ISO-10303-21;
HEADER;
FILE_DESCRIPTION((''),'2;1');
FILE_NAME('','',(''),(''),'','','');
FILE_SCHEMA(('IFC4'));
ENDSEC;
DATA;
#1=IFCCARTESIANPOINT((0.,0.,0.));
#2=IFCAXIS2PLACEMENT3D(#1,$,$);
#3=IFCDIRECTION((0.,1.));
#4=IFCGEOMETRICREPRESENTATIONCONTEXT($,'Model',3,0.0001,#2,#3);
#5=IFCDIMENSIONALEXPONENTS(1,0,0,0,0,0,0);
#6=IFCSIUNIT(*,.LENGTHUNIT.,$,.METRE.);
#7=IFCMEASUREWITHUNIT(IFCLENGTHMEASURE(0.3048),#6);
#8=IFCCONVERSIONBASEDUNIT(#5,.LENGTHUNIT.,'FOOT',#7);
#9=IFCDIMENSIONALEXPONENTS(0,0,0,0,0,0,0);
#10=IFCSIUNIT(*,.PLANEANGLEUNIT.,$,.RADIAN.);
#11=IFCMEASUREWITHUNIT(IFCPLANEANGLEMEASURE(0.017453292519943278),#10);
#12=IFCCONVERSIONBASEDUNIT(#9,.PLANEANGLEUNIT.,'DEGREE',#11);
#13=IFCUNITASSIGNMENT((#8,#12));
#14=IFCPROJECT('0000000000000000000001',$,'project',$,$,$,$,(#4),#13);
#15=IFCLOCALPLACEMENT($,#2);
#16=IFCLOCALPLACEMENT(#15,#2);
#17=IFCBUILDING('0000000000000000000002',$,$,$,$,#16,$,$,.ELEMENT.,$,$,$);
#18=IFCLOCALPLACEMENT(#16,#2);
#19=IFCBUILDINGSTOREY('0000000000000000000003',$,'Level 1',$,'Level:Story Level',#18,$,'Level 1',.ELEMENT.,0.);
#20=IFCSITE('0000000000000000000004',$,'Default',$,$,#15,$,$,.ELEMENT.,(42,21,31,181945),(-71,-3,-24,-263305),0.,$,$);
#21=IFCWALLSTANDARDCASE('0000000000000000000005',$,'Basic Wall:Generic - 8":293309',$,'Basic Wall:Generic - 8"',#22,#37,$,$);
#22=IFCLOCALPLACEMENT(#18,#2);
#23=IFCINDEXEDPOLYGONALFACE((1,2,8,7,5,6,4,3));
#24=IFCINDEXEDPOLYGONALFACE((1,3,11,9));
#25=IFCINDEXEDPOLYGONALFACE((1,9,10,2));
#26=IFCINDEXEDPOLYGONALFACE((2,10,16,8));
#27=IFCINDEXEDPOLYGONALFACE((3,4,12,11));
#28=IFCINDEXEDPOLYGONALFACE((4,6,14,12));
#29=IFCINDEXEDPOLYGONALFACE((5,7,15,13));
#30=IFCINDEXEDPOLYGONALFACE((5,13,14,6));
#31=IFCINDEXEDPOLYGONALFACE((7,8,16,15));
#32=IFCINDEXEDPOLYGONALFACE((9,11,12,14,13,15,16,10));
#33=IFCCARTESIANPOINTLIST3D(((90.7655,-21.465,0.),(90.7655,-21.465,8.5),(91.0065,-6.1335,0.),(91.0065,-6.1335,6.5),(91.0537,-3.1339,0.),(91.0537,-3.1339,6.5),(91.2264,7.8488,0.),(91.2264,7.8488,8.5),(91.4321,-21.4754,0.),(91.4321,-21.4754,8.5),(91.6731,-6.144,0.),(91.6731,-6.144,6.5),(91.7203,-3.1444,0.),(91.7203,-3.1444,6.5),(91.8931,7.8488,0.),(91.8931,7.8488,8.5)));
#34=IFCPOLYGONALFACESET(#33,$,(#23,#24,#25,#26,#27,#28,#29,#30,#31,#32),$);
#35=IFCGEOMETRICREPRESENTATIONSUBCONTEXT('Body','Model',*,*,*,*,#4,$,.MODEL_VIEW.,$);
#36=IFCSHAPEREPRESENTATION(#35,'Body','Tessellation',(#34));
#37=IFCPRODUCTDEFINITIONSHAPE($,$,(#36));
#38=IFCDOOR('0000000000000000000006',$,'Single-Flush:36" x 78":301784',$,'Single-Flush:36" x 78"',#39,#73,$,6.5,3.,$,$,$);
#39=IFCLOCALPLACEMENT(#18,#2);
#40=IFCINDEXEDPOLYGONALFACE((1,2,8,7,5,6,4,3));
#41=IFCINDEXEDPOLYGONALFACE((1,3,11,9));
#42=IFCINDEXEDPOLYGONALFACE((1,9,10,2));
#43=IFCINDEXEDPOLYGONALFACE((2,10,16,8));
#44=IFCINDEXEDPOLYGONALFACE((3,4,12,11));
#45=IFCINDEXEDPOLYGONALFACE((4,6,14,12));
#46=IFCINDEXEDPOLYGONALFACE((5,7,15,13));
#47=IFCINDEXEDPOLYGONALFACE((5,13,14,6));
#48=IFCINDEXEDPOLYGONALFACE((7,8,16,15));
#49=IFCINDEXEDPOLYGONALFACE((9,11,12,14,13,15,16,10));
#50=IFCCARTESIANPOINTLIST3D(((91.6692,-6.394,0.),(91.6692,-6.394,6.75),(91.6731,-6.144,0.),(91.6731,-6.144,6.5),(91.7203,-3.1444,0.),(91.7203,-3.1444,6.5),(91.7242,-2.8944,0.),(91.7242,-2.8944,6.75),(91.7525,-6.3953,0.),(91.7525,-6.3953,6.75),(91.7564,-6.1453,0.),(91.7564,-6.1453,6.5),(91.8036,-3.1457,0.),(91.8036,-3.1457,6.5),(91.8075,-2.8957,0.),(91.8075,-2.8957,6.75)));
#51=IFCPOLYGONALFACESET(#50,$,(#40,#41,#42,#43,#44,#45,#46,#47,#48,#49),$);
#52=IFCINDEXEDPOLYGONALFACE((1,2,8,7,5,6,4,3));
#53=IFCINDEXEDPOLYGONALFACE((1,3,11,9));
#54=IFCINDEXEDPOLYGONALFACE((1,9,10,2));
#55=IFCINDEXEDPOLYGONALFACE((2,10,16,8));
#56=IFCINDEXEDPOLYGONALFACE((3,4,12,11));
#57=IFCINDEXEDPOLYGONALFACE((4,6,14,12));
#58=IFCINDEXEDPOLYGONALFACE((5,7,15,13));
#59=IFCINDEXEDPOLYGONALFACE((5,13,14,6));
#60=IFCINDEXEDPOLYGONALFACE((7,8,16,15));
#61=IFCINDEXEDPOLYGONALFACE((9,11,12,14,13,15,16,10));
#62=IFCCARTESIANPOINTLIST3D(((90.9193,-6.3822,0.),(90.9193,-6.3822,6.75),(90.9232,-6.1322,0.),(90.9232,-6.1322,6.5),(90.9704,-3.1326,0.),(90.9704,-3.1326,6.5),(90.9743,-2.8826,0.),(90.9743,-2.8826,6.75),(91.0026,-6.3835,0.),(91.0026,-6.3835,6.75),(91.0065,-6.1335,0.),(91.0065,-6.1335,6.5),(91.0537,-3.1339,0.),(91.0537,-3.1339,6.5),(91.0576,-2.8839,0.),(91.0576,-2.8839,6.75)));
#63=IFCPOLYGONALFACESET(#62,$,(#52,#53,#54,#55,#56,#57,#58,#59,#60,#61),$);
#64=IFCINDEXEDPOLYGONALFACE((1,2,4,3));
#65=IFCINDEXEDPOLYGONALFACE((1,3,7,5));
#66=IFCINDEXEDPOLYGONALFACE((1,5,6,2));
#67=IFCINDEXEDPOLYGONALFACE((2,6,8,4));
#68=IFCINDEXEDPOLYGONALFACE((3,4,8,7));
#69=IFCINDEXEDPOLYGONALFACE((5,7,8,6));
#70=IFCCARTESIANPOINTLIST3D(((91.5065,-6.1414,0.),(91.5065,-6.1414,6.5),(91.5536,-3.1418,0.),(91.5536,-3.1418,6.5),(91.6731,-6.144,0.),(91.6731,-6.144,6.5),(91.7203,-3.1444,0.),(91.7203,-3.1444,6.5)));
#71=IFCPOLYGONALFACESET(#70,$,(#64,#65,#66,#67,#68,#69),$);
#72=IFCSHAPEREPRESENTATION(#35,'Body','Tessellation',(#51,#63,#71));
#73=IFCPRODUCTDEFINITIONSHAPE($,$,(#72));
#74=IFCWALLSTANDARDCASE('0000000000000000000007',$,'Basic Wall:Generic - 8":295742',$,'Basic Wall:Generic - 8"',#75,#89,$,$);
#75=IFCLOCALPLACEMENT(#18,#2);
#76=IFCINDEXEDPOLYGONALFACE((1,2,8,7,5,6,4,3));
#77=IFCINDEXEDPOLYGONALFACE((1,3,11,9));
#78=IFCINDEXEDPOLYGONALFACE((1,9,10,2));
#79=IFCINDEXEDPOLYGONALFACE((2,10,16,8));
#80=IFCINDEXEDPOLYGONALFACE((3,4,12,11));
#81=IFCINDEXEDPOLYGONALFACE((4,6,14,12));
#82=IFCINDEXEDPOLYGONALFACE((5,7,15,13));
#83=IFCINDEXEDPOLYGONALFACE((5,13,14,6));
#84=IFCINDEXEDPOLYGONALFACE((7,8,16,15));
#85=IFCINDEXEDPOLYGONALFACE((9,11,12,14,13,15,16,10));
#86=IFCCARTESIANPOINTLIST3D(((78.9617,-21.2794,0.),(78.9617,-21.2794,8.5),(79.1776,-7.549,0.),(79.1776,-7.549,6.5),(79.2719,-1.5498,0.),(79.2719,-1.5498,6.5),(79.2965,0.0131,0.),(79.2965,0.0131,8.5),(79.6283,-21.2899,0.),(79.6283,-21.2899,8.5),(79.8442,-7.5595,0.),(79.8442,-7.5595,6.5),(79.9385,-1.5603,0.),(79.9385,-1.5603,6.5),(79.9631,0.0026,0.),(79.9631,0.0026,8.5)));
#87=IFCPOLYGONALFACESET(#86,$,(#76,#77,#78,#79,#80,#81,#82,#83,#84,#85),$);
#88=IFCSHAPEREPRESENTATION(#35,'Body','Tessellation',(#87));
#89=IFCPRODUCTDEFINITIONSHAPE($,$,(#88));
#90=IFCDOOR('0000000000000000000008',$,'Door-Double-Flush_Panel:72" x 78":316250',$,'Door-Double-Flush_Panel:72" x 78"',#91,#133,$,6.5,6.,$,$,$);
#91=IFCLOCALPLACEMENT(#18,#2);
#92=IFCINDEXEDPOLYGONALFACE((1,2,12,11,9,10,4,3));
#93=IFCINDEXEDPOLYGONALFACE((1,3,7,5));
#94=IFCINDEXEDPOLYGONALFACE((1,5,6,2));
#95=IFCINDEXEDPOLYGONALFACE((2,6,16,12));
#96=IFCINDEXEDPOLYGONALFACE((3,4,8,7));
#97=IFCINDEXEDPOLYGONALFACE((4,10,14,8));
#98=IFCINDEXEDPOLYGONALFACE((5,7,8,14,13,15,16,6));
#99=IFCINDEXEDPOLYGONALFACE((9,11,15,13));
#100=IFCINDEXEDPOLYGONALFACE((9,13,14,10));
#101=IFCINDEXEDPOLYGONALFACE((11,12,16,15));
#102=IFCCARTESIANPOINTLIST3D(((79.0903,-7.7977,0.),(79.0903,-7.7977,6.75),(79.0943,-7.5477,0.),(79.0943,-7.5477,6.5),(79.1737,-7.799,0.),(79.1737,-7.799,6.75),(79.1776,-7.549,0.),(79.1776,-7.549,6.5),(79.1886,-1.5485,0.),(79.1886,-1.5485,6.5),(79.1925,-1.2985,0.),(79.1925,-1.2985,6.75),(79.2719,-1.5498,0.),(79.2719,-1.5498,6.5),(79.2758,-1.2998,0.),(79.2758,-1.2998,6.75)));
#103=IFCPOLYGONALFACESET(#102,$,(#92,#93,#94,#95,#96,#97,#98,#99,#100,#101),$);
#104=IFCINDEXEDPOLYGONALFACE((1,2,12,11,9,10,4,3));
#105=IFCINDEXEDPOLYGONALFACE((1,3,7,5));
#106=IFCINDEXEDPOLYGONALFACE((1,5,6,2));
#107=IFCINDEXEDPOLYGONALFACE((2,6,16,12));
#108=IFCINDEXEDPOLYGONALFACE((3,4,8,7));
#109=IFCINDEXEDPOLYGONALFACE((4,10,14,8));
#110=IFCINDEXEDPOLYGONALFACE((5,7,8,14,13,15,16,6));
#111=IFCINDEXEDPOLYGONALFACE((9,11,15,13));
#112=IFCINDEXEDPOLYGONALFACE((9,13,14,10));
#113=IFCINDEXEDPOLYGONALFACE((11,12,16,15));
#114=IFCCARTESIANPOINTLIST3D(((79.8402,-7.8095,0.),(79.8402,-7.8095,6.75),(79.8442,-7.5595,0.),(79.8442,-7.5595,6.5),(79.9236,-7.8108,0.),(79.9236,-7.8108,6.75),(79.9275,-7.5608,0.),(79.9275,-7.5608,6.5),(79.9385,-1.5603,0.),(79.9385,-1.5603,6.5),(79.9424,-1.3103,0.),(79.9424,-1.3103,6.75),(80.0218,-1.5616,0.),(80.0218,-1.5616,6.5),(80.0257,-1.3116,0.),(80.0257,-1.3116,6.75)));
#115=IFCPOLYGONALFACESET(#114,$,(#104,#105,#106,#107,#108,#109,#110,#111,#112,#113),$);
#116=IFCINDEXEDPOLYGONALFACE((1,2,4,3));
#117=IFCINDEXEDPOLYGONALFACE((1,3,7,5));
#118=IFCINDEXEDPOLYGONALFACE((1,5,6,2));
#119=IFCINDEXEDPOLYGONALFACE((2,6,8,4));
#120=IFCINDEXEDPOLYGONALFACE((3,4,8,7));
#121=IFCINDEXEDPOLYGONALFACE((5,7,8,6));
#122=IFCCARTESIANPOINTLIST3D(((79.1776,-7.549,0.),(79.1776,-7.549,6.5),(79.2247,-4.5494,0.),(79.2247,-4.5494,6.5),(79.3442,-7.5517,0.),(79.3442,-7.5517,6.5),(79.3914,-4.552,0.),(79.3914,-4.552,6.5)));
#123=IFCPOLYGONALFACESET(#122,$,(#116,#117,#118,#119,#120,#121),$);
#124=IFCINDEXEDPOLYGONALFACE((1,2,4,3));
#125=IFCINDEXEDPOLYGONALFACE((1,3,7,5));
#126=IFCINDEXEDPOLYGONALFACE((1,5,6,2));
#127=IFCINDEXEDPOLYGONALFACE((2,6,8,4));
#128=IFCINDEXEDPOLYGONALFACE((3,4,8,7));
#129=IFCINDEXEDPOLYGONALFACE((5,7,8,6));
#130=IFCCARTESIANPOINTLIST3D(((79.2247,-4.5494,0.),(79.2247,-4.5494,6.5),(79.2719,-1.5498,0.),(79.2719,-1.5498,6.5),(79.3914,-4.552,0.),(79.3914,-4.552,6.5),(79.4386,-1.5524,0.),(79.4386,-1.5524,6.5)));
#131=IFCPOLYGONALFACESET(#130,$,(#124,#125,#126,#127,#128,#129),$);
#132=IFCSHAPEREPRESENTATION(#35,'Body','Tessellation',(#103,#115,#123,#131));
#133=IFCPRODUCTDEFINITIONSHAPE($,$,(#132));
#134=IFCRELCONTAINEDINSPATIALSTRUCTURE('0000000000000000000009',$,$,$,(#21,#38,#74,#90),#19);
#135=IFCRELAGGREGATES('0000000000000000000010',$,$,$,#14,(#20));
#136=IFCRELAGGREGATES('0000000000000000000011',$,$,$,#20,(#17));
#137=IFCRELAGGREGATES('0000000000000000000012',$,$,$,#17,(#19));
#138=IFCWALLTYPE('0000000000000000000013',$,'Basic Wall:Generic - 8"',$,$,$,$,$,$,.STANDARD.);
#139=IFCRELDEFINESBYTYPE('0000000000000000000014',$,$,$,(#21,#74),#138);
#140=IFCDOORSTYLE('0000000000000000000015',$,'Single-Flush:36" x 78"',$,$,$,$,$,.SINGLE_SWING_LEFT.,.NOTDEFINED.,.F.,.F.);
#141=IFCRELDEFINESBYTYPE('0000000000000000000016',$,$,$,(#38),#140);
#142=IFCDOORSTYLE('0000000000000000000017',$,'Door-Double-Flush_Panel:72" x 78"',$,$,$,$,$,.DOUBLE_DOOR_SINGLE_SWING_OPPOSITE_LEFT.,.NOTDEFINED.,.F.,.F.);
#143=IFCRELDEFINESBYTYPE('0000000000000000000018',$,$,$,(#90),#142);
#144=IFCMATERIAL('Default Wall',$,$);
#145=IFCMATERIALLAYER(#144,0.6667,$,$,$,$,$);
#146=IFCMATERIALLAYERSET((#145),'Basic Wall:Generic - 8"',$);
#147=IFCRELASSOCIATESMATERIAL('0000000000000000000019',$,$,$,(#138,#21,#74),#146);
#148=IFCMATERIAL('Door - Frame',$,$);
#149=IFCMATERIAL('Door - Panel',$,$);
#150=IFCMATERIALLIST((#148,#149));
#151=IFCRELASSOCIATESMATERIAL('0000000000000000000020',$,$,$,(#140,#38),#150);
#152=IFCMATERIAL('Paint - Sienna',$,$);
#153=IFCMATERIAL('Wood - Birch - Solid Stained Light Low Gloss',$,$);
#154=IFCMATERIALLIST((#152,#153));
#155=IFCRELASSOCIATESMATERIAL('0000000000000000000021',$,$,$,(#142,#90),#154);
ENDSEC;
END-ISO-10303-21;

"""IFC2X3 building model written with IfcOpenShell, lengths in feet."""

from ifc_helpers import new_model, entity, si_unit, converted_unit, direction, frame, frame_2d, origin, place, context, subcontext, project, spatial, polyline, rectangle, outline, extrude, source, transform, mapped, material, material_list, layer, layer_set, layer_usage, type_object, type_shapes, element, fill, save


model = new_model("IFC2X3")

# Units and contexts
model_context = context("Model", 3, precision=0.0001, world=origin(), true_north=direction((0.0, 1.0)))
body_context = subcontext(model_context, "Body", "Model", "MODEL_VIEW")
ifc_project = project(units=[converted_unit("LENGTHUNIT", "FOOT", entity("IfcLengthMeasure", 0.3048), si_unit("LENGTHUNIT", "METRE"), dimensions=[1, 0, 0, 0, 0, 0, 0]), converted_unit("PLANEANGLEUNIT", "DEGREE", entity("IfcPlaneAngleMeasure", 0.017453292519943278), si_unit("PLANEANGLEUNIT", "RADIAN"), dimensions=[0, 0, 0, 0, 0, 0, 0])], contexts=[model_context])

# Site, building, storey
site_placement = place(None, origin())
site = spatial("IfcSite", under=ifc_project, at=site_placement, Name="Default", CompositionType="ELEMENT", RefLatitude=(42, 21, 31, 181945), RefLongitude=(-71, -3, -24, -263305), RefElevation=0.0)
building_placement = place(site_placement, origin())
building = spatial("IfcBuilding", under=site, at=building_placement, CompositionType="ELEMENT")
storey_placement = place(building_placement, origin())
storey = spatial("IfcBuildingStorey", under=building, at=storey_placement, Name="Level 1", ObjectType="Level:Story Level", LongName="Level 1", CompositionType="ELEMENT", Elevation=0.0)

# Walls, openings, doors
ifc_material_1 = material(Name="Default Wall")
ifc_layer_1 = layer(ifc_material_1, 0.6667)
ifc_layer_set_1 = layer_set([ifc_layer_1], Name="Basic Wall:Generic - 8\"")
ifc_layer_usage_1 = layer_usage(ifc_layer_set_1, "AXIS2", "NEGATIVE", 0.3333)
wall_type_1 = type_object("IfcWallType", Name="Basic Wall:Generic - 8\"", PredefinedType="STANDARD", material=ifc_layer_set_1)
wall_1_placement = place(storey_placement, frame((91.5598, 7.8541, 0.0), z_axis=(0.0, 0.0, 1.0), x_axis=(-0.015721, -0.999876, 0.0)))
wall_1 = element("IfcWallStandardCase", 1, at=wall_1_placement, inside=storey, type_object=wall_type_1, material=ifc_layer_usage_1, Name="Basic Wall:Generic - 8\":293309", ObjectType="Basic Wall:Generic - 8\"", context=body_context, shape_type="SweptSolid", body=[
    extrude(outline(polyline([(0.0105, -0.3333), (29.3279, -0.3333), (29.3279, 0.3333), (10.5258, 0.3333), (10.1195, 0.3333), (0.0, 0.3333), (0.0105, -0.3333)])), origin(), (0.0, 0.0, 1.0), 8.5),
])
opening_1_placement = place(wall_1_placement, frame((10.9946, -0.3333, 0.0)))
opening_1 = element("IfcOpeningElement", 2, at=opening_1_placement, cuts=wall_1, ObjectType="Opening", context=body_context, shape_type="SweptSolid", body=[
    extrude(rectangle(XDim=3.0, YDim=6.5, at=frame_2d((3.25, 1.5), x_axis=(0.0, -1.0))), frame((0.0, 0.0, 0.0), z_axis=(0.0, 1.0, 0.0), x_axis=(0.0, 0.0, 1.0)), (0.0, 0.0, 1.0), 0.6667),
])
ifc_material_2 = material(Name="Door - Frame")
ifc_material_3 = material(Name="Door - Panel")
ifc_material_list_1 = material_list([ifc_material_2, ifc_material_3])
door_style_1 = type_object("IfcDoorStyle", Name="Single-Flush:36\" x 78\"", ConstructionType="NOTDEFINED", OperationType="SINGLE_SWING_LEFT", ParameterTakesPrecedence=False, Sizeable=False, material=ifc_material_list_1)
shared_shape_1 = source(origin(), body_context, "Body", "SweptSolid", [
    extrude(outline(polyline([(-1.75, -3.4375), (1.75, -3.4375), (1.75, 3.3125), (1.5, 3.3125), (1.5, -3.1875), (-1.5, -3.1875), (-1.5, 3.3125), (-1.75, 3.3125), (-1.75, -3.4375)])), frame((1.5, 0.75, 3.3125), z_axis=(0.0, -1.0, 0.0), x_axis=(-1.0, 0.0, 0.0)), (0.0, 0.0, 1.0), 0.0833),
    extrude(outline(polyline([(-3.4375, -1.75), (3.3125, -1.75), (3.3125, -1.5), (-3.1875, -1.5), (-3.1875, 1.5), (3.3125, 1.5), (3.3125, 1.75), (-3.4375, 1.75), (-3.4375, -1.75)])), frame((1.5, 0.0, 3.3125), z_axis=(0.0, -1.0, 0.0), x_axis=(0.0, 0.0, -1.0)), (0.0, 0.0, 1.0), 0.0833),
    extrude(rectangle(XDim=3.0, YDim=0.1667, at=frame_2d((0.0, 0.0), x_axis=(1.0, 0.0))), frame((1.5, 0.5833, 0.0)), (0.0, 0.0, 1.0), 6.5),
])
type_shapes(door_style_1, [shared_shape_1])
door_1_placement = place(opening_1_placement, origin())
door_1 = element("IfcDoor", 3, at=door_1_placement, inside=storey, type_object=door_style_1, material=ifc_material_list_1, Name="Single-Flush:36\" x 78\":301784", ObjectType="Single-Flush:36\" x 78\"", OverallHeight=6.5, OverallWidth=3.0, context=body_context, shape_type="MappedRepresentation", body=[
    mapped(shared_shape_1, transform((0.0, 0.0, 0.0), scale=1.0)),
])
fill(opening_1, door_1)
ifc_layer_usage_2 = layer_usage(ifc_layer_set_1, "AXIS2", "NEGATIVE", 0.3333)
wall_2_placement = place(storey_placement, frame((79.6298, 0.0079, 0.0), z_axis=(0.0, 0.0, 1.0), x_axis=(-0.015721, -0.999876, 0.0)))
wall_2 = element("IfcWallStandardCase", 4, at=wall_2_placement, inside=storey, type_object=wall_type_1, material=ifc_layer_usage_2, Name="Basic Wall:Generic - 8\":295742", ObjectType="Basic Wall:Generic - 8\"", context=body_context, shape_type="SweptSolid", body=[
    extrude(rectangle(XDim=21.2951, YDim=0.6667, at=frame_2d((10.6476, 0.0), x_axis=(-1.0, 0.0))), origin(), (0.0, 0.0, 1.0), 8.5),
])
opening_2_placement = place(wall_2_placement, frame((7.5631, 0.3333, 0.0)))
opening_2 = element("IfcOpeningElement", 5, at=opening_2_placement, cuts=wall_2, ObjectType="Opening", context=body_context, shape_type="SweptSolid", body=[
    extrude(rectangle(XDim=6.5, YDim=6.0, at=frame_2d((3.25, 3.0), x_axis=(1.0, 0.0))), frame((0.0, 0.0, 0.0), z_axis=(0.0, -1.0, 0.0), x_axis=(0.0, 0.0, 1.0)), (0.0, 0.0, 1.0), 0.6667),
])
ifc_material_4 = material(Name="Paint - Sienna")
ifc_material_5 = material(Name="Wood - Birch - Solid Stained Light Low Gloss")
ifc_material_list_2 = material_list([ifc_material_4, ifc_material_5])
door_style_2 = type_object("IfcDoorStyle", Name="Door-Double-Flush_Panel:72\" x 78\"", ConstructionType="NOTDEFINED", OperationType="DOUBLE_DOOR_SINGLE_SWING_OPPOSITE_LEFT", ParameterTakesPrecedence=False, Sizeable=False, material=ifc_material_list_2)
shared_shape_2 = source(origin(), body_context, "Body", "SweptSolid", [
    extrude(outline(polyline([(-3.1875, 3.0), (3.3125, 3.0), (3.3125, 3.25), (-3.4375, 3.25), (-3.4375, -3.25), (3.3125, -3.25), (3.3125, -3.0), (-3.1875, -3.0), (-3.1875, 3.0)])), frame((3.0, 0.6667, 3.3125), z_axis=(0.0, 1.0, 0.0), x_axis=(0.0, 0.0, -1.0)), (0.0, 0.0, 1.0), 0.0833),
    extrude(outline(polyline([(-3.1875, 3.0), (3.3125, 3.0), (3.3125, 3.25), (-3.4375, 3.25), (-3.4375, -3.25), (3.3125, -3.25), (3.3125, -3.0), (-3.1875, -3.0), (-3.1875, 3.0)])), frame((3.0, -0.0833, 3.3125), z_axis=(0.0, 1.0, 0.0), x_axis=(0.0, 0.0, -1.0)), (0.0, 0.0, 1.0), 0.0833),
    extrude(rectangle(XDim=0.1667, YDim=3.0, at=frame_2d((0.0, 0.0), x_axis=(1.0, 0.0))), frame((1.5, 0.5833, 0.0), z_axis=(0.0, 0.0, 1.0), x_axis=(0.0, -1.0, 0.0)), (0.0, 0.0, 1.0), 6.5),
    extrude(rectangle(XDim=0.1667, YDim=3.0, at=frame_2d((0.0, 0.0), x_axis=(1.0, 0.0))), frame((4.5, 0.5833, 0.0), z_axis=(0.0, 0.0, 1.0), x_axis=(0.0, -1.0, 0.0)), (0.0, 0.0, 1.0), 6.5),
])
type_shapes(door_style_2, [shared_shape_2])
door_2_placement = place(opening_2_placement, frame((0.0, 0.0, 0.0), z_axis=(0.0, 0.0, 1.0), x_axis=(-1.0, 0.0, 0.0)))
door_2 = element("IfcDoor", 6, at=door_2_placement, inside=storey, type_object=door_style_2, material=ifc_material_list_2, Name="Door-Double-Flush_Panel:72\" x 78\":316250", ObjectType="Door-Double-Flush_Panel:72\" x 78\"", OverallHeight=6.5, OverallWidth=6.0, context=body_context, shape_type="MappedRepresentation", body=[
    mapped(shared_shape_2, transform((0.0, 0.0, 0.0), scale=1.0)),
])
fill(opening_2, door_2)

save(model, "model.ifc")
